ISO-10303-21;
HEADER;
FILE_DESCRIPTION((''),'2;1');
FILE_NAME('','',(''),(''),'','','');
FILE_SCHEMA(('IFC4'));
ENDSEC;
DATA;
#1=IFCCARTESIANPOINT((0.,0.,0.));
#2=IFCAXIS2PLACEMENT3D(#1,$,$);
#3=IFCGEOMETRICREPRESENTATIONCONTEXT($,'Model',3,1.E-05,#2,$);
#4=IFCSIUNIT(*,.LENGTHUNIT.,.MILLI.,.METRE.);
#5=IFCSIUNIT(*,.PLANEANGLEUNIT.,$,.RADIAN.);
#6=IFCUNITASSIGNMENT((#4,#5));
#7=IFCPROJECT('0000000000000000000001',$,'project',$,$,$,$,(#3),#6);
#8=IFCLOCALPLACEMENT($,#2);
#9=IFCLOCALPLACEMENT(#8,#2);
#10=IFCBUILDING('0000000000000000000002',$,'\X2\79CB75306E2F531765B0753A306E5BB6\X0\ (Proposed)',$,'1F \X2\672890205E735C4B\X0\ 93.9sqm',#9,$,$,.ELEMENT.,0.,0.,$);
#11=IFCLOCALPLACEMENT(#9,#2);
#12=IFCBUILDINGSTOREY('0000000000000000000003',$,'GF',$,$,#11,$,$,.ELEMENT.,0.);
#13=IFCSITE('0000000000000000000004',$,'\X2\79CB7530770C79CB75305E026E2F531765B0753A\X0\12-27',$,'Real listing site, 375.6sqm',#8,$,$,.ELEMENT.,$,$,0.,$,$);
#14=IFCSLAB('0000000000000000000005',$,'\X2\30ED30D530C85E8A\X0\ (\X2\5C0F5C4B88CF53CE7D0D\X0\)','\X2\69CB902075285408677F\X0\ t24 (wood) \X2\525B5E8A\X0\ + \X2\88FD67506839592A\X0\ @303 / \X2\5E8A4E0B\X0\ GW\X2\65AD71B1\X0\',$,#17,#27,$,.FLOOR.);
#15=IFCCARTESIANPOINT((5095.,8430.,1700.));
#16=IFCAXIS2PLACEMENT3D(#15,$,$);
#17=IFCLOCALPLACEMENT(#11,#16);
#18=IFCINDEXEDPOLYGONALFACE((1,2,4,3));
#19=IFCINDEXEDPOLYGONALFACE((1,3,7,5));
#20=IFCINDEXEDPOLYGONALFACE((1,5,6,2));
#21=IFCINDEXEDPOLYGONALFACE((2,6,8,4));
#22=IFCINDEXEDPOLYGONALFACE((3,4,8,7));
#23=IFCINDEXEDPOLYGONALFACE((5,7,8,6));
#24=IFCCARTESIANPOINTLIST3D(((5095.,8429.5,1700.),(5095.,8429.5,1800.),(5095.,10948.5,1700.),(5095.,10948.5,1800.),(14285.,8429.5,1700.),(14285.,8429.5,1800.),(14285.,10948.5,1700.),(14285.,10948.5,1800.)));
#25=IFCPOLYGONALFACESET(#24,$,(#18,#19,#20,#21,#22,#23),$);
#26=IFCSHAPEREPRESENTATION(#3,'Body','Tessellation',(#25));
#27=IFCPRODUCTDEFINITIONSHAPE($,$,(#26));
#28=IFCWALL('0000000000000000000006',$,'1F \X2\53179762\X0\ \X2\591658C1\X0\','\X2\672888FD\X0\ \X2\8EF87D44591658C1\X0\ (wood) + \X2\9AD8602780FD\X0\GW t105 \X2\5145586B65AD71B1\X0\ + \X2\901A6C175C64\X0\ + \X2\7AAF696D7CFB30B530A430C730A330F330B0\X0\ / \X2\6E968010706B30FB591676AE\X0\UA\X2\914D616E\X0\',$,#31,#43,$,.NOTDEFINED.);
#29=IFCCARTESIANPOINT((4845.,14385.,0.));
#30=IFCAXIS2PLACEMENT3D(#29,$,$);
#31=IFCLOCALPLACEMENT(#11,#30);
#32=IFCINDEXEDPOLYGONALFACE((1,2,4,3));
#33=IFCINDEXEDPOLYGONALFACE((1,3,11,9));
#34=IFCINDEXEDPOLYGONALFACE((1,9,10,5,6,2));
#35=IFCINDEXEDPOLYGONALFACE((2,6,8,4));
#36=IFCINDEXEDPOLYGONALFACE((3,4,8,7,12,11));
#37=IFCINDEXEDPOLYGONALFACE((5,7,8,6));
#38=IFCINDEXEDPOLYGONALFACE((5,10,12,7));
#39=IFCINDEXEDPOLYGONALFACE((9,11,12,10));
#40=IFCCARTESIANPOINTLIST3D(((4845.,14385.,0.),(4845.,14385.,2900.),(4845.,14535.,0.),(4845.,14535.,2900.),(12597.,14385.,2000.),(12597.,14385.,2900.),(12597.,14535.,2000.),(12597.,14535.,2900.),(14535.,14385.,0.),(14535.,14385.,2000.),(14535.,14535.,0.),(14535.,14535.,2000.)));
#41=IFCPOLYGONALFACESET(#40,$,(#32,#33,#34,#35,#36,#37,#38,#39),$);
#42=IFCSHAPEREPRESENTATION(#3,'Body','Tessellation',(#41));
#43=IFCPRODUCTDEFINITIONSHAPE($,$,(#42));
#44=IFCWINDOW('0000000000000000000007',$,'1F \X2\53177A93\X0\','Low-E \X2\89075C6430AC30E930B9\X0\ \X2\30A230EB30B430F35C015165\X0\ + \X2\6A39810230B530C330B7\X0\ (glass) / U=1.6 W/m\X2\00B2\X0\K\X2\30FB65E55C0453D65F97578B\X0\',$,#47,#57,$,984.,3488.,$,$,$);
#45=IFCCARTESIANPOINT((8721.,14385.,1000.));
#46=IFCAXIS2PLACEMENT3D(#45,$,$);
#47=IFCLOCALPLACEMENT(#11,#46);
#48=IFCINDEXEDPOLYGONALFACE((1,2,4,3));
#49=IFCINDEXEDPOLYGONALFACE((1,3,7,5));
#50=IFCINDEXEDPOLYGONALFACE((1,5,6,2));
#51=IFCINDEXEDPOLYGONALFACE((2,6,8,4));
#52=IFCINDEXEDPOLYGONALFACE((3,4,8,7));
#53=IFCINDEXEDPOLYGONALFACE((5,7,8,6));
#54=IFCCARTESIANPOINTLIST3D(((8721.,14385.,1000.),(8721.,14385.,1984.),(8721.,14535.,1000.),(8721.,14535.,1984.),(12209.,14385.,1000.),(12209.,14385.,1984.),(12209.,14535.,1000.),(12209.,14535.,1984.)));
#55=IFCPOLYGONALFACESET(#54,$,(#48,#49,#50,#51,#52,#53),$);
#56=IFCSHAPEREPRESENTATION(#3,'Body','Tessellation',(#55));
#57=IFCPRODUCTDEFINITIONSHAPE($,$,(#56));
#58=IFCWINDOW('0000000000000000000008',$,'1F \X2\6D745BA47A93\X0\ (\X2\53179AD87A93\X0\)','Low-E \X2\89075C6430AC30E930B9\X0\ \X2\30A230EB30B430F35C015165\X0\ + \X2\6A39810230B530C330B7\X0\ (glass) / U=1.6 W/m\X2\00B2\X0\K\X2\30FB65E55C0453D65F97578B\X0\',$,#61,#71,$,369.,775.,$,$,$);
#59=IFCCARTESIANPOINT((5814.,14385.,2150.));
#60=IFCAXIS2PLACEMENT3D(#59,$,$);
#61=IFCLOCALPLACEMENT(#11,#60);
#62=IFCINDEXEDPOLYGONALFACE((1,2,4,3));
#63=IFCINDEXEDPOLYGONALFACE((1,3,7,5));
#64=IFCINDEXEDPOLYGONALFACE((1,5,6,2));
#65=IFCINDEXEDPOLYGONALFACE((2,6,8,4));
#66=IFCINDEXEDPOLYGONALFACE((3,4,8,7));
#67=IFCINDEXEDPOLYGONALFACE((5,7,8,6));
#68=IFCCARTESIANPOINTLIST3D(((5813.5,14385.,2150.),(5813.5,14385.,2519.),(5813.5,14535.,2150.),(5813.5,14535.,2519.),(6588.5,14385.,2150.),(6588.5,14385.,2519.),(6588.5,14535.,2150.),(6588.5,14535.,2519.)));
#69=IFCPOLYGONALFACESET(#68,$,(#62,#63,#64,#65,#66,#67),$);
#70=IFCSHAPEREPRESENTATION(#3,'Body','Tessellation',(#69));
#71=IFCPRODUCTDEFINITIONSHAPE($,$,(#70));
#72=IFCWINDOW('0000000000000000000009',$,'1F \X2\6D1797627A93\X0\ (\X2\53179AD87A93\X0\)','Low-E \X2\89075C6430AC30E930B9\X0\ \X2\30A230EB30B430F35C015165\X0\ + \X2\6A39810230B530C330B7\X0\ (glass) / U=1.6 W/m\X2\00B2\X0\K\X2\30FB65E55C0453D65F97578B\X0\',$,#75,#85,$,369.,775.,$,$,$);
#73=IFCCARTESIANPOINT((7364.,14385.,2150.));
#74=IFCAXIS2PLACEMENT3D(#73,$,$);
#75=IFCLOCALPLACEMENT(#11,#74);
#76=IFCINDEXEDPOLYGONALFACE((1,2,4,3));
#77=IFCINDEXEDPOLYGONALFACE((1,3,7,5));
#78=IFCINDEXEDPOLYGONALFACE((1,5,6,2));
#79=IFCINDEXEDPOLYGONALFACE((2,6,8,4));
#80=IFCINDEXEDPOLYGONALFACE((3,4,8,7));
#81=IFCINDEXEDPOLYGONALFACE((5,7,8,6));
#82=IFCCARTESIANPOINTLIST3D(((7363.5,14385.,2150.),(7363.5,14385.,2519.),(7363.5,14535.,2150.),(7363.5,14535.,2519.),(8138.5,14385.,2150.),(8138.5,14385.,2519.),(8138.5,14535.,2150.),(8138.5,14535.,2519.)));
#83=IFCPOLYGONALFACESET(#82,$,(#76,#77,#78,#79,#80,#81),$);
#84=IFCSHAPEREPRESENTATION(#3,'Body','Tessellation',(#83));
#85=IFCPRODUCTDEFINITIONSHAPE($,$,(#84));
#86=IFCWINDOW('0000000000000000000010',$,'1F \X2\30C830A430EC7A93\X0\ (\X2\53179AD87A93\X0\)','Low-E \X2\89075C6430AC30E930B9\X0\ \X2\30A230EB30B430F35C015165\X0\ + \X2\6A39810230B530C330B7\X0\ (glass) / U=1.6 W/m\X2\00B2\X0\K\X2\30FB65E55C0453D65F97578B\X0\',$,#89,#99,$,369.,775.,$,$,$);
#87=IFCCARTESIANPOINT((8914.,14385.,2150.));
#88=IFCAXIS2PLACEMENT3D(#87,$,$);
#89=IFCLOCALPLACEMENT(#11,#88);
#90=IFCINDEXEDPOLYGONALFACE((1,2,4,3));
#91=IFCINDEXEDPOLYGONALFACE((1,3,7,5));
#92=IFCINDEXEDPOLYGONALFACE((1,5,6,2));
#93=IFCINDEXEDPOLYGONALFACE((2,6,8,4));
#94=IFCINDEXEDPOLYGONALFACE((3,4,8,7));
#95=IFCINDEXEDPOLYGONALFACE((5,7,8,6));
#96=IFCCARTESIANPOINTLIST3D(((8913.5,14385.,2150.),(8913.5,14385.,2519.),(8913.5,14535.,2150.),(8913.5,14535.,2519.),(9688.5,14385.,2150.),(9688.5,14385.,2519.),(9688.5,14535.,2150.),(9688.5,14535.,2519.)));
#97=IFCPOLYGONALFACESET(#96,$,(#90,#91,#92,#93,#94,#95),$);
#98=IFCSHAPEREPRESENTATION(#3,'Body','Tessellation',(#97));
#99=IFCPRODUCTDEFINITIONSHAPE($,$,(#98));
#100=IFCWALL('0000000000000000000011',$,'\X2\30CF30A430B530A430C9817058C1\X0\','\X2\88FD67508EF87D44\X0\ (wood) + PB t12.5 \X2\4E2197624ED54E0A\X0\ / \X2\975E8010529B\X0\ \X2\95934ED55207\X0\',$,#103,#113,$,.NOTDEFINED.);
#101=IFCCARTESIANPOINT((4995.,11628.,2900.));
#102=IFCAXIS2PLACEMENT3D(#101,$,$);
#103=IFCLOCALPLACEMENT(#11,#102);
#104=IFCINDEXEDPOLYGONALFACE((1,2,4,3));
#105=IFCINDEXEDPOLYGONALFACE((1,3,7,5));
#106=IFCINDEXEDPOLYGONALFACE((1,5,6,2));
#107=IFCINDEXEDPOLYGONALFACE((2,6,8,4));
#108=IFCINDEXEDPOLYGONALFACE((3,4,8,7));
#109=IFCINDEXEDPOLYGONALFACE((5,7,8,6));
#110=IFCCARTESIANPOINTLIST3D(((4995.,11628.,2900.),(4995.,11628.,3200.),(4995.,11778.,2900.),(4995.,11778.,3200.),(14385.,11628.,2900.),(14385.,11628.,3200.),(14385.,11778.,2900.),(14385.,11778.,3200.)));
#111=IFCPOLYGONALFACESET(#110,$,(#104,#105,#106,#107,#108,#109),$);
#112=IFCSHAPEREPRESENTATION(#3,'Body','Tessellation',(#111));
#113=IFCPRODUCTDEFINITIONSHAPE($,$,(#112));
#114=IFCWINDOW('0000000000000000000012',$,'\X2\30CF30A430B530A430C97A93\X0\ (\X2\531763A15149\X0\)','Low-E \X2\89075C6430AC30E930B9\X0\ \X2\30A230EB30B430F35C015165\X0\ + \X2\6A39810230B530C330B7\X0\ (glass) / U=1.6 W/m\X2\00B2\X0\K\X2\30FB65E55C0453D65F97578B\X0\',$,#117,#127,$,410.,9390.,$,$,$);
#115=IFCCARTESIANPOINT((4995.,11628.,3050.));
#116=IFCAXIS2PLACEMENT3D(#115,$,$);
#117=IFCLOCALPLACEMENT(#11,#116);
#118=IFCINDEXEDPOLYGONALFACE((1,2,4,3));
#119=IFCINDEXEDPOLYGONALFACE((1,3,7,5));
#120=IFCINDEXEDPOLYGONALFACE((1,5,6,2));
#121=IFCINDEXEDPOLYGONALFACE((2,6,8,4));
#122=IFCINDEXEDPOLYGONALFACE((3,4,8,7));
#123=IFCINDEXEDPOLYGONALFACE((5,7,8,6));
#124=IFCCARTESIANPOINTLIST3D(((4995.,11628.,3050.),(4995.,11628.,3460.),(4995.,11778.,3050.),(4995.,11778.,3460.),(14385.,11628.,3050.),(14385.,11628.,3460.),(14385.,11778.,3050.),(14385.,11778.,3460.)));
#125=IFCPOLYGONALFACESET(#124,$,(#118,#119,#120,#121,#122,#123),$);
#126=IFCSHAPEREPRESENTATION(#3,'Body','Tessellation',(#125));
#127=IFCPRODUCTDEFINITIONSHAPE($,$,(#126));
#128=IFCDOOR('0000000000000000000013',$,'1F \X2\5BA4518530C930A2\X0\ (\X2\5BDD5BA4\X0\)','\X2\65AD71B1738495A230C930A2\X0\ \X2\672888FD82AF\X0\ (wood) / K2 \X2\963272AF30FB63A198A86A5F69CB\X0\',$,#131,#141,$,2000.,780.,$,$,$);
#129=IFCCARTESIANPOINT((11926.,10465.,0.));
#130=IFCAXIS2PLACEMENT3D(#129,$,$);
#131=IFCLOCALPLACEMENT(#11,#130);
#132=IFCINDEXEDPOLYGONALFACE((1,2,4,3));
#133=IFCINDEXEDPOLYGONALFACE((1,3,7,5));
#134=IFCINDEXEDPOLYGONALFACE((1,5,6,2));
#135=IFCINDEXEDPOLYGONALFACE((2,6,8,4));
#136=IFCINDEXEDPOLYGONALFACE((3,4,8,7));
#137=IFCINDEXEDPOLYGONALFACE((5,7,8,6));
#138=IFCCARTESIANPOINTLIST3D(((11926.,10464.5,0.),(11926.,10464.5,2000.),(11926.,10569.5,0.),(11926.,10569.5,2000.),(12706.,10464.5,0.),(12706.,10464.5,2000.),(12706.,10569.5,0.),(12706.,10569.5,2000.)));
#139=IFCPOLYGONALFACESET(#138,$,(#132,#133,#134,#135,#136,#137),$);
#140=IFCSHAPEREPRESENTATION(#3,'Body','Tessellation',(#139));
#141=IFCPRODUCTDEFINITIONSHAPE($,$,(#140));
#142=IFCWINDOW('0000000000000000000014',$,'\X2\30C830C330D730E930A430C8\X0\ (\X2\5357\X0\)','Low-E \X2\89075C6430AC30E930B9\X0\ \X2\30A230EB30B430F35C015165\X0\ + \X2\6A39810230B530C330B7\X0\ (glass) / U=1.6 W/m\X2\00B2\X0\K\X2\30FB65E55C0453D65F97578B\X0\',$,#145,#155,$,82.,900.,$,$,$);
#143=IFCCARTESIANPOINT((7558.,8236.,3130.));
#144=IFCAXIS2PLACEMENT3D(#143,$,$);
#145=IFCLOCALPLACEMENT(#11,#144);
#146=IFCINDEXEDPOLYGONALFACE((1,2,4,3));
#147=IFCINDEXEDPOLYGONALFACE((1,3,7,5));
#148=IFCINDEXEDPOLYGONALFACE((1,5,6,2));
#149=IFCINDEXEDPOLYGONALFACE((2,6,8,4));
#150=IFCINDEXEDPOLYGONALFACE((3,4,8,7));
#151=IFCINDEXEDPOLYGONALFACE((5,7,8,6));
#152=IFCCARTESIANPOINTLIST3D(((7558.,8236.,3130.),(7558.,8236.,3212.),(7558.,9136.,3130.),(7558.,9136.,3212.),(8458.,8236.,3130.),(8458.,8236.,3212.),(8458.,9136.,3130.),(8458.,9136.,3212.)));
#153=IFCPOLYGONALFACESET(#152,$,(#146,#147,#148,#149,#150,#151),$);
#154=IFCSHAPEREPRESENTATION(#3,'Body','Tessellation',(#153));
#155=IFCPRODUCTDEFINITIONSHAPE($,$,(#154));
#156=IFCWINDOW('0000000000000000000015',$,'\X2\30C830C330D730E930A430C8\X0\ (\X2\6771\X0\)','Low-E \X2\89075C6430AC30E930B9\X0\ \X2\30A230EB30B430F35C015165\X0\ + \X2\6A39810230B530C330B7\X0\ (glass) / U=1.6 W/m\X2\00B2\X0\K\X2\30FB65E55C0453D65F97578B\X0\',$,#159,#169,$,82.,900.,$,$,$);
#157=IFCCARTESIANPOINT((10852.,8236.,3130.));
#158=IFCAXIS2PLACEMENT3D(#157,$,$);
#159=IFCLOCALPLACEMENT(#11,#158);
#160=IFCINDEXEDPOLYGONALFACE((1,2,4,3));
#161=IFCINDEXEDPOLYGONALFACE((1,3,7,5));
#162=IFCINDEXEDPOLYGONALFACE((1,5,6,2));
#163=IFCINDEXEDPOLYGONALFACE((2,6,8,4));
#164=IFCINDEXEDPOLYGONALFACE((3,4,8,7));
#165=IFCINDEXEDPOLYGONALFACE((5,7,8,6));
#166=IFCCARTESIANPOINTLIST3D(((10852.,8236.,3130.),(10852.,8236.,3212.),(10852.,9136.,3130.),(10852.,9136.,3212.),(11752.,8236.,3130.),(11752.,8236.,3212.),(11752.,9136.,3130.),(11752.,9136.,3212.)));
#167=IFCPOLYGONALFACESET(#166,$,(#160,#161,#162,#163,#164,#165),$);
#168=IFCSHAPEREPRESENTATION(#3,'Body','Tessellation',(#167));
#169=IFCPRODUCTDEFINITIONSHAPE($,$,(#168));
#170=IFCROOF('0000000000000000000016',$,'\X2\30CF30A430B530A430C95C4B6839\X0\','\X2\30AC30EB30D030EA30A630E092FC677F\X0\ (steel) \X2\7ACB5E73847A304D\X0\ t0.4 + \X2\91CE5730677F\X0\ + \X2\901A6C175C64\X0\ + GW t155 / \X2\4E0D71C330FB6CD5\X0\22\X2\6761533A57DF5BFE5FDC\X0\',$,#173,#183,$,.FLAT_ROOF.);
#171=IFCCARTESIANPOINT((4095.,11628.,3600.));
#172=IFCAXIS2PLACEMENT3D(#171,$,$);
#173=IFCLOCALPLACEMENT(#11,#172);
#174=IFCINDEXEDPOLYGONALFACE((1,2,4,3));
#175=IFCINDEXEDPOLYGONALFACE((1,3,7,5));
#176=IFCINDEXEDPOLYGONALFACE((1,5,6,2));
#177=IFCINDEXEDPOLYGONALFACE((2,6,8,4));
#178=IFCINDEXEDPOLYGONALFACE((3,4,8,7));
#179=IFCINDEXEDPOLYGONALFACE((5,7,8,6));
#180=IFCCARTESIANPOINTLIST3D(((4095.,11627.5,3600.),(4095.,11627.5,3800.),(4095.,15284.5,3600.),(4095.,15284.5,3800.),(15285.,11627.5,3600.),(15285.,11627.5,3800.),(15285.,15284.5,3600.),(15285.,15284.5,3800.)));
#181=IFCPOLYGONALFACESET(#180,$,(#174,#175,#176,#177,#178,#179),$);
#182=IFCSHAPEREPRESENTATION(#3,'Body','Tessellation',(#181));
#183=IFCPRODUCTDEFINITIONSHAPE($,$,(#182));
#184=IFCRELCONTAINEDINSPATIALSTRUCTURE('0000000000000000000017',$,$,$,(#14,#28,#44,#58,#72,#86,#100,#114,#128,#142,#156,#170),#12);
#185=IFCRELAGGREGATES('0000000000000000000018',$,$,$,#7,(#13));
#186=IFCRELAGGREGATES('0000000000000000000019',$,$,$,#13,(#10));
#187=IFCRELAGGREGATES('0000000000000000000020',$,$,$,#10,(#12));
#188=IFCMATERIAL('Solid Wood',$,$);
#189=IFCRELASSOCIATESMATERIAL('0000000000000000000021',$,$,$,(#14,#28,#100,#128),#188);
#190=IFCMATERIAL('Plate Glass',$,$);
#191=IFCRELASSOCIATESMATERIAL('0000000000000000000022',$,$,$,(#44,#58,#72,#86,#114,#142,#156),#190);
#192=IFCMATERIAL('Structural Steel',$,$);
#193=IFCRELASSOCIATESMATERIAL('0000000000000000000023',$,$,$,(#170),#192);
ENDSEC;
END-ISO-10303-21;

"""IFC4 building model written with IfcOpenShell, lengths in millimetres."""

from ifc_helpers import new_model, si_unit, frame, frame_2d, origin, place, context, project, spatial, rectangle, extrude, material, element, fill, save


model = new_model("IFC4")

# Units and contexts
model_context = context("Model", 3, precision=1e-05, world=origin())
ifc_project = project(units=[si_unit("LENGTHUNIT", "METRE", prefix="MILLI"), si_unit("PLANEANGLEUNIT", "RADIAN")], contexts=[model_context])

# Site, building, storey
site_placement = place(None, origin())
site = spatial("IfcSite", under=ifc_project, at=site_placement, Name="秋田県秋田市港北新町12-27", ObjectType="Real listing site, 375.6sqm", CompositionType="ELEMENT", RefElevation=0.0)
building_placement = place(site_placement, origin())
building = spatial("IfcBuilding", under=site, at=building_placement, Name="秋田港北新町の家 (Proposed)", ObjectType="1F 木造平屋 93.9sqm", CompositionType="ELEMENT", ElevationOfRefHeight=0.0, ElevationOfTerrain=0.0)
storey_placement = place(building_placement, origin())
storey = spatial("IfcBuildingStorey", under=building, at=storey_placement, Name="GF", CompositionType="ELEMENT", Elevation=0.0)

# Slab
ifc_material_1 = material(Name="Solid Wood")
slab_placement = place(storey_placement, frame((5095.0, 8430.0, 1700.0)))
element("IfcSlab", 1, at=slab_placement, inside=storey, material=ifc_material_1, Name="ロフト床 (小屋裏収納)", Description="構造用合板 t24 (wood) 剛床 + 製材根太 @303 / 床下 GW断熱", PredefinedType="FLOOR", context=model_context, shape_type="SweptSolid", body=[
    extrude(rectangle(XDim=9190.0, YDim=2519.0, at=frame_2d((4595.0, 1259.0))), frame((5095.0, 8430.0, 1700.0)), (0.0, 0.0, 1.0), 100.0),
])

# Wall, openings, windows
wall_1_placement = place(storey_placement, frame((4845.0, 14385.0, 0.0)))
wall_1 = element("IfcWall", 2, at=wall_1_placement, inside=storey, material=ifc_material_1, Name="1F 北面 外壁", Description="木製 軸組外壁 (wood) + 高性能GW t105 充填断熱 + 通気層 + 窯業系サイディング / 準耐火・外皮UA配慮", PredefinedType="NOTDEFINED", context=model_context, shape_type="SweptSolid", body=[
    extrude(rectangle(XDim=9690.0, YDim=150.0, at=frame_2d((4845.0, 75.0))), frame((4845.0, 14385.0, 0.0)), (0.0, 0.0, 1.0), 2900.0),
])
opening_1_placement = place(storey_placement, frame((8721.0, 14385.0, 1000.0)))
opening_1 = element("IfcOpeningElement", 3, at=opening_1_placement, cuts=wall_1, PredefinedType="NOTDEFINED", context=model_context, shape_type="SweptSolid", body=[
    extrude(rectangle(XDim=3488.0, YDim=150.0, at=frame_2d((1744.0, 75.0))), frame((8721.0, 14385.0, 1000.0)), (0.0, 0.0, 1.0), 984.0),
])
opening_2_placement = place(storey_placement, frame((5814.0, 14385.0, 2150.0)))
opening_2 = element("IfcOpeningElement", 4, at=opening_2_placement, cuts=wall_1, PredefinedType="NOTDEFINED", context=model_context, shape_type="SweptSolid", body=[
    extrude(rectangle(XDim=775.0, YDim=150.0, at=frame_2d((387.0, 75.0))), frame((5814.0, 14385.0, 2150.0)), (0.0, 0.0, 1.0), 369.0),
])
opening_3_placement = place(storey_placement, frame((7364.0, 14385.0, 2150.0)))
opening_3 = element("IfcOpeningElement", 5, at=opening_3_placement, cuts=wall_1, PredefinedType="NOTDEFINED", context=model_context, shape_type="SweptSolid", body=[
    extrude(rectangle(XDim=775.0, YDim=150.0, at=frame_2d((387.0, 75.0))), frame((7364.0, 14385.0, 2150.0)), (0.0, 0.0, 1.0), 369.0),
])
opening_4_placement = place(storey_placement, frame((8914.0, 14385.0, 2150.0)))
opening_4 = element("IfcOpeningElement", 6, at=opening_4_placement, cuts=wall_1, PredefinedType="NOTDEFINED", context=model_context, shape_type="SweptSolid", body=[
    extrude(rectangle(XDim=775.0, YDim=150.0, at=frame_2d((387.0, 75.0))), frame((8914.0, 14385.0, 2150.0)), (0.0, 0.0, 1.0), 369.0),
])
ifc_material_2 = material(Name="Plate Glass")
window_1_placement = place(storey_placement, frame((8721.0, 14385.0, 1000.0)))
window_1 = element("IfcWindow", 7, at=window_1_placement, inside=storey, material=ifc_material_2, Name="1F 北窓", Description="Low-E 複層ガラス アルゴン封入 + 樹脂サッシ (glass) / U=1.6 W/m²K・日射取得型", OverallHeight=984.0, OverallWidth=3488.0, context=model_context, shape_type="SweptSolid", body=[
    extrude(rectangle(XDim=3488.0, YDim=150.0, at=frame_2d((1744.0, 75.0))), frame((8721.0, 14385.0, 1000.0)), (0.0, 0.0, 1.0), 984.0),
])
fill(opening_1, window_1)
window_2_placement = place(storey_placement, frame((5814.0, 14385.0, 2150.0)))
window_2 = element("IfcWindow", 8, at=window_2_placement, inside=storey, material=ifc_material_2, Name="1F 浴室窓 (北高窓)", Description="Low-E 複層ガラス アルゴン封入 + 樹脂サッシ (glass) / U=1.6 W/m²K・日射取得型", OverallHeight=369.0, OverallWidth=775.0, context=model_context, shape_type="SweptSolid", body=[
    extrude(rectangle(XDim=775.0, YDim=150.0, at=frame_2d((387.0, 75.0))), frame((5814.0, 14385.0, 2150.0)), (0.0, 0.0, 1.0), 369.0),
])
fill(opening_2, window_2)
window_3_placement = place(storey_placement, frame((7364.0, 14385.0, 2150.0)))
window_3 = element("IfcWindow", 9, at=window_3_placement, inside=storey, material=ifc_material_2, Name="1F 洗面窓 (北高窓)", Description="Low-E 複層ガラス アルゴン封入 + 樹脂サッシ (glass) / U=1.6 W/m²K・日射取得型", OverallHeight=369.0, OverallWidth=775.0, context=model_context, shape_type="SweptSolid", body=[
    extrude(rectangle(XDim=775.0, YDim=150.0, at=frame_2d((387.0, 75.0))), frame((7364.0, 14385.0, 2150.0)), (0.0, 0.0, 1.0), 369.0),
])
fill(opening_3, window_3)
window_4_placement = place(storey_placement, frame((8914.0, 14385.0, 2150.0)))
window_4 = element("IfcWindow", 10, at=window_4_placement, inside=storey, material=ifc_material_2, Name="1F トイレ窓 (北高窓)", Description="Low-E 複層ガラス アルゴン封入 + 樹脂サッシ (glass) / U=1.6 W/m²K・日射取得型", OverallHeight=369.0, OverallWidth=775.0, context=model_context, shape_type="SweptSolid", body=[
    extrude(rectangle(XDim=775.0, YDim=150.0, at=frame_2d((387.0, 75.0))), frame((8914.0, 14385.0, 2150.0)), (0.0, 0.0, 1.0), 369.0),
])
fill(opening_4, window_4)

# Wall, opening, window
wall_2_placement = place(storey_placement, frame((4995.0, 11628.0, 2900.0)))
wall_2 = element("IfcWall", 11, at=wall_2_placement, inside=storey, material=ifc_material_1, Name="ハイサイド腰壁", Description="製材軸組 (wood) + PB t12.5 両面仕上 / 非耐力 間仕切", PredefinedType="NOTDEFINED", context=model_context, shape_type="SweptSolid", body=[
    extrude(rectangle(XDim=9390.0, YDim=150.0, at=frame_2d((4695.0, 75.0))), frame((4995.0, 11628.0, 2900.0)), (0.0, 0.0, 1.0), 700.0),
])
opening_5_placement = place(storey_placement, frame((4995.0, 11628.0, 3050.0)))
opening_5 = element("IfcOpeningElement", 12, at=opening_5_placement, cuts=wall_2, PredefinedType="NOTDEFINED", context=model_context, shape_type="SweptSolid", body=[
    extrude(rectangle(XDim=9390.0, YDim=150.0, at=frame_2d((4695.0, 75.0))), frame((4995.0, 11628.0, 3050.0)), (0.0, 0.0, 1.0), 410.0),
])
window_5_placement = place(storey_placement, frame((4995.0, 11628.0, 3050.0)))
window_5 = element("IfcWindow", 13, at=window_5_placement, inside=storey, material=ifc_material_2, Name="ハイサイド窓 (北採光)", Description="Low-E 複層ガラス アルゴン封入 + 樹脂サッシ (glass) / U=1.6 W/m²K・日射取得型", OverallHeight=410.0, OverallWidth=9390.0, context=model_context, shape_type="SweptSolid", body=[
    extrude(rectangle(XDim=9390.0, YDim=150.0, at=frame_2d((4695.0, 75.0))), frame((4995.0, 11628.0, 3050.0)), (0.0, 0.0, 1.0), 410.0),
])
fill(opening_5, window_5)

# Door
door_1_placement = place(storey_placement, frame((11926.0, 10465.0, 0.0)))
element("IfcDoor", 14, at=door_1_placement, inside=storey, material=ifc_material_1, Name="1F 室内ドア (寝室)", Description="断熱玄関ドア 木製芯 (wood) / K2 防犯・採風機構", OverallHeight=2000.0, OverallWidth=780.0, context=model_context, shape_type="SweptSolid", body=[
    extrude(rectangle(XDim=780.0, YDim=105.0, at=frame_2d((390.0, 52.0))), frame((11926.0, 10465.0, 0.0)), (0.0, 0.0, 1.0), 2000.0),
])

# Windows
window_6_placement = place(storey_placement, frame((7558.0, 8236.0, 3130.0)))
element("IfcWindow", 15, at=window_6_placement, inside=storey, material=ifc_material_2, Name="トップライト (南)", Description="Low-E 複層ガラス アルゴン封入 + 樹脂サッシ (glass) / U=1.6 W/m²K・日射取得型", OverallHeight=82.0, OverallWidth=900.0, context=model_context, shape_type="SweptSolid", body=[
    extrude(rectangle(XDim=900.0, YDim=900.0, at=frame_2d((450.0, 450.0))), frame((7558.0, 8236.0, 3130.0)), (0.0, 0.0, 1.0), 82.0),
])
window_7_placement = place(storey_placement, frame((10852.0, 8236.0, 3130.0)))
element("IfcWindow", 16, at=window_7_placement, inside=storey, material=ifc_material_2, Name="トップライト (東)", Description="Low-E 複層ガラス アルゴン封入 + 樹脂サッシ (glass) / U=1.6 W/m²K・日射取得型", OverallHeight=82.0, OverallWidth=900.0, context=model_context, shape_type="SweptSolid", body=[
    extrude(rectangle(XDim=900.0, YDim=900.0, at=frame_2d((450.0, 450.0))), frame((10852.0, 8236.0, 3130.0)), (0.0, 0.0, 1.0), 82.0),
])

# Roof
ifc_material_3 = material(Name="Structural Steel")
roof_placement = place(storey_placement, frame((4095.0, 11628.0, 3600.0)))
element("IfcRoof", 17, at=roof_placement, inside=storey, material=ifc_material_3, Name="ハイサイド屋根", Description="ガルバリウム鋼板 (steel) 立平葺き t0.4 + 野地板 + 通気層 + GW t155 / 不燃・法22条区域対応", PredefinedType="FLAT_ROOF", context=model_context, shape_type="SweptSolid", body=[
    extrude(rectangle(XDim=11190.0, YDim=3657.0, at=frame_2d((5595.0, 1828.0))), frame((4095.0, 11628.0, 3600.0)), (0.0, 0.0, 1.0), 200.0),
])

save(model, "model.ifc")
